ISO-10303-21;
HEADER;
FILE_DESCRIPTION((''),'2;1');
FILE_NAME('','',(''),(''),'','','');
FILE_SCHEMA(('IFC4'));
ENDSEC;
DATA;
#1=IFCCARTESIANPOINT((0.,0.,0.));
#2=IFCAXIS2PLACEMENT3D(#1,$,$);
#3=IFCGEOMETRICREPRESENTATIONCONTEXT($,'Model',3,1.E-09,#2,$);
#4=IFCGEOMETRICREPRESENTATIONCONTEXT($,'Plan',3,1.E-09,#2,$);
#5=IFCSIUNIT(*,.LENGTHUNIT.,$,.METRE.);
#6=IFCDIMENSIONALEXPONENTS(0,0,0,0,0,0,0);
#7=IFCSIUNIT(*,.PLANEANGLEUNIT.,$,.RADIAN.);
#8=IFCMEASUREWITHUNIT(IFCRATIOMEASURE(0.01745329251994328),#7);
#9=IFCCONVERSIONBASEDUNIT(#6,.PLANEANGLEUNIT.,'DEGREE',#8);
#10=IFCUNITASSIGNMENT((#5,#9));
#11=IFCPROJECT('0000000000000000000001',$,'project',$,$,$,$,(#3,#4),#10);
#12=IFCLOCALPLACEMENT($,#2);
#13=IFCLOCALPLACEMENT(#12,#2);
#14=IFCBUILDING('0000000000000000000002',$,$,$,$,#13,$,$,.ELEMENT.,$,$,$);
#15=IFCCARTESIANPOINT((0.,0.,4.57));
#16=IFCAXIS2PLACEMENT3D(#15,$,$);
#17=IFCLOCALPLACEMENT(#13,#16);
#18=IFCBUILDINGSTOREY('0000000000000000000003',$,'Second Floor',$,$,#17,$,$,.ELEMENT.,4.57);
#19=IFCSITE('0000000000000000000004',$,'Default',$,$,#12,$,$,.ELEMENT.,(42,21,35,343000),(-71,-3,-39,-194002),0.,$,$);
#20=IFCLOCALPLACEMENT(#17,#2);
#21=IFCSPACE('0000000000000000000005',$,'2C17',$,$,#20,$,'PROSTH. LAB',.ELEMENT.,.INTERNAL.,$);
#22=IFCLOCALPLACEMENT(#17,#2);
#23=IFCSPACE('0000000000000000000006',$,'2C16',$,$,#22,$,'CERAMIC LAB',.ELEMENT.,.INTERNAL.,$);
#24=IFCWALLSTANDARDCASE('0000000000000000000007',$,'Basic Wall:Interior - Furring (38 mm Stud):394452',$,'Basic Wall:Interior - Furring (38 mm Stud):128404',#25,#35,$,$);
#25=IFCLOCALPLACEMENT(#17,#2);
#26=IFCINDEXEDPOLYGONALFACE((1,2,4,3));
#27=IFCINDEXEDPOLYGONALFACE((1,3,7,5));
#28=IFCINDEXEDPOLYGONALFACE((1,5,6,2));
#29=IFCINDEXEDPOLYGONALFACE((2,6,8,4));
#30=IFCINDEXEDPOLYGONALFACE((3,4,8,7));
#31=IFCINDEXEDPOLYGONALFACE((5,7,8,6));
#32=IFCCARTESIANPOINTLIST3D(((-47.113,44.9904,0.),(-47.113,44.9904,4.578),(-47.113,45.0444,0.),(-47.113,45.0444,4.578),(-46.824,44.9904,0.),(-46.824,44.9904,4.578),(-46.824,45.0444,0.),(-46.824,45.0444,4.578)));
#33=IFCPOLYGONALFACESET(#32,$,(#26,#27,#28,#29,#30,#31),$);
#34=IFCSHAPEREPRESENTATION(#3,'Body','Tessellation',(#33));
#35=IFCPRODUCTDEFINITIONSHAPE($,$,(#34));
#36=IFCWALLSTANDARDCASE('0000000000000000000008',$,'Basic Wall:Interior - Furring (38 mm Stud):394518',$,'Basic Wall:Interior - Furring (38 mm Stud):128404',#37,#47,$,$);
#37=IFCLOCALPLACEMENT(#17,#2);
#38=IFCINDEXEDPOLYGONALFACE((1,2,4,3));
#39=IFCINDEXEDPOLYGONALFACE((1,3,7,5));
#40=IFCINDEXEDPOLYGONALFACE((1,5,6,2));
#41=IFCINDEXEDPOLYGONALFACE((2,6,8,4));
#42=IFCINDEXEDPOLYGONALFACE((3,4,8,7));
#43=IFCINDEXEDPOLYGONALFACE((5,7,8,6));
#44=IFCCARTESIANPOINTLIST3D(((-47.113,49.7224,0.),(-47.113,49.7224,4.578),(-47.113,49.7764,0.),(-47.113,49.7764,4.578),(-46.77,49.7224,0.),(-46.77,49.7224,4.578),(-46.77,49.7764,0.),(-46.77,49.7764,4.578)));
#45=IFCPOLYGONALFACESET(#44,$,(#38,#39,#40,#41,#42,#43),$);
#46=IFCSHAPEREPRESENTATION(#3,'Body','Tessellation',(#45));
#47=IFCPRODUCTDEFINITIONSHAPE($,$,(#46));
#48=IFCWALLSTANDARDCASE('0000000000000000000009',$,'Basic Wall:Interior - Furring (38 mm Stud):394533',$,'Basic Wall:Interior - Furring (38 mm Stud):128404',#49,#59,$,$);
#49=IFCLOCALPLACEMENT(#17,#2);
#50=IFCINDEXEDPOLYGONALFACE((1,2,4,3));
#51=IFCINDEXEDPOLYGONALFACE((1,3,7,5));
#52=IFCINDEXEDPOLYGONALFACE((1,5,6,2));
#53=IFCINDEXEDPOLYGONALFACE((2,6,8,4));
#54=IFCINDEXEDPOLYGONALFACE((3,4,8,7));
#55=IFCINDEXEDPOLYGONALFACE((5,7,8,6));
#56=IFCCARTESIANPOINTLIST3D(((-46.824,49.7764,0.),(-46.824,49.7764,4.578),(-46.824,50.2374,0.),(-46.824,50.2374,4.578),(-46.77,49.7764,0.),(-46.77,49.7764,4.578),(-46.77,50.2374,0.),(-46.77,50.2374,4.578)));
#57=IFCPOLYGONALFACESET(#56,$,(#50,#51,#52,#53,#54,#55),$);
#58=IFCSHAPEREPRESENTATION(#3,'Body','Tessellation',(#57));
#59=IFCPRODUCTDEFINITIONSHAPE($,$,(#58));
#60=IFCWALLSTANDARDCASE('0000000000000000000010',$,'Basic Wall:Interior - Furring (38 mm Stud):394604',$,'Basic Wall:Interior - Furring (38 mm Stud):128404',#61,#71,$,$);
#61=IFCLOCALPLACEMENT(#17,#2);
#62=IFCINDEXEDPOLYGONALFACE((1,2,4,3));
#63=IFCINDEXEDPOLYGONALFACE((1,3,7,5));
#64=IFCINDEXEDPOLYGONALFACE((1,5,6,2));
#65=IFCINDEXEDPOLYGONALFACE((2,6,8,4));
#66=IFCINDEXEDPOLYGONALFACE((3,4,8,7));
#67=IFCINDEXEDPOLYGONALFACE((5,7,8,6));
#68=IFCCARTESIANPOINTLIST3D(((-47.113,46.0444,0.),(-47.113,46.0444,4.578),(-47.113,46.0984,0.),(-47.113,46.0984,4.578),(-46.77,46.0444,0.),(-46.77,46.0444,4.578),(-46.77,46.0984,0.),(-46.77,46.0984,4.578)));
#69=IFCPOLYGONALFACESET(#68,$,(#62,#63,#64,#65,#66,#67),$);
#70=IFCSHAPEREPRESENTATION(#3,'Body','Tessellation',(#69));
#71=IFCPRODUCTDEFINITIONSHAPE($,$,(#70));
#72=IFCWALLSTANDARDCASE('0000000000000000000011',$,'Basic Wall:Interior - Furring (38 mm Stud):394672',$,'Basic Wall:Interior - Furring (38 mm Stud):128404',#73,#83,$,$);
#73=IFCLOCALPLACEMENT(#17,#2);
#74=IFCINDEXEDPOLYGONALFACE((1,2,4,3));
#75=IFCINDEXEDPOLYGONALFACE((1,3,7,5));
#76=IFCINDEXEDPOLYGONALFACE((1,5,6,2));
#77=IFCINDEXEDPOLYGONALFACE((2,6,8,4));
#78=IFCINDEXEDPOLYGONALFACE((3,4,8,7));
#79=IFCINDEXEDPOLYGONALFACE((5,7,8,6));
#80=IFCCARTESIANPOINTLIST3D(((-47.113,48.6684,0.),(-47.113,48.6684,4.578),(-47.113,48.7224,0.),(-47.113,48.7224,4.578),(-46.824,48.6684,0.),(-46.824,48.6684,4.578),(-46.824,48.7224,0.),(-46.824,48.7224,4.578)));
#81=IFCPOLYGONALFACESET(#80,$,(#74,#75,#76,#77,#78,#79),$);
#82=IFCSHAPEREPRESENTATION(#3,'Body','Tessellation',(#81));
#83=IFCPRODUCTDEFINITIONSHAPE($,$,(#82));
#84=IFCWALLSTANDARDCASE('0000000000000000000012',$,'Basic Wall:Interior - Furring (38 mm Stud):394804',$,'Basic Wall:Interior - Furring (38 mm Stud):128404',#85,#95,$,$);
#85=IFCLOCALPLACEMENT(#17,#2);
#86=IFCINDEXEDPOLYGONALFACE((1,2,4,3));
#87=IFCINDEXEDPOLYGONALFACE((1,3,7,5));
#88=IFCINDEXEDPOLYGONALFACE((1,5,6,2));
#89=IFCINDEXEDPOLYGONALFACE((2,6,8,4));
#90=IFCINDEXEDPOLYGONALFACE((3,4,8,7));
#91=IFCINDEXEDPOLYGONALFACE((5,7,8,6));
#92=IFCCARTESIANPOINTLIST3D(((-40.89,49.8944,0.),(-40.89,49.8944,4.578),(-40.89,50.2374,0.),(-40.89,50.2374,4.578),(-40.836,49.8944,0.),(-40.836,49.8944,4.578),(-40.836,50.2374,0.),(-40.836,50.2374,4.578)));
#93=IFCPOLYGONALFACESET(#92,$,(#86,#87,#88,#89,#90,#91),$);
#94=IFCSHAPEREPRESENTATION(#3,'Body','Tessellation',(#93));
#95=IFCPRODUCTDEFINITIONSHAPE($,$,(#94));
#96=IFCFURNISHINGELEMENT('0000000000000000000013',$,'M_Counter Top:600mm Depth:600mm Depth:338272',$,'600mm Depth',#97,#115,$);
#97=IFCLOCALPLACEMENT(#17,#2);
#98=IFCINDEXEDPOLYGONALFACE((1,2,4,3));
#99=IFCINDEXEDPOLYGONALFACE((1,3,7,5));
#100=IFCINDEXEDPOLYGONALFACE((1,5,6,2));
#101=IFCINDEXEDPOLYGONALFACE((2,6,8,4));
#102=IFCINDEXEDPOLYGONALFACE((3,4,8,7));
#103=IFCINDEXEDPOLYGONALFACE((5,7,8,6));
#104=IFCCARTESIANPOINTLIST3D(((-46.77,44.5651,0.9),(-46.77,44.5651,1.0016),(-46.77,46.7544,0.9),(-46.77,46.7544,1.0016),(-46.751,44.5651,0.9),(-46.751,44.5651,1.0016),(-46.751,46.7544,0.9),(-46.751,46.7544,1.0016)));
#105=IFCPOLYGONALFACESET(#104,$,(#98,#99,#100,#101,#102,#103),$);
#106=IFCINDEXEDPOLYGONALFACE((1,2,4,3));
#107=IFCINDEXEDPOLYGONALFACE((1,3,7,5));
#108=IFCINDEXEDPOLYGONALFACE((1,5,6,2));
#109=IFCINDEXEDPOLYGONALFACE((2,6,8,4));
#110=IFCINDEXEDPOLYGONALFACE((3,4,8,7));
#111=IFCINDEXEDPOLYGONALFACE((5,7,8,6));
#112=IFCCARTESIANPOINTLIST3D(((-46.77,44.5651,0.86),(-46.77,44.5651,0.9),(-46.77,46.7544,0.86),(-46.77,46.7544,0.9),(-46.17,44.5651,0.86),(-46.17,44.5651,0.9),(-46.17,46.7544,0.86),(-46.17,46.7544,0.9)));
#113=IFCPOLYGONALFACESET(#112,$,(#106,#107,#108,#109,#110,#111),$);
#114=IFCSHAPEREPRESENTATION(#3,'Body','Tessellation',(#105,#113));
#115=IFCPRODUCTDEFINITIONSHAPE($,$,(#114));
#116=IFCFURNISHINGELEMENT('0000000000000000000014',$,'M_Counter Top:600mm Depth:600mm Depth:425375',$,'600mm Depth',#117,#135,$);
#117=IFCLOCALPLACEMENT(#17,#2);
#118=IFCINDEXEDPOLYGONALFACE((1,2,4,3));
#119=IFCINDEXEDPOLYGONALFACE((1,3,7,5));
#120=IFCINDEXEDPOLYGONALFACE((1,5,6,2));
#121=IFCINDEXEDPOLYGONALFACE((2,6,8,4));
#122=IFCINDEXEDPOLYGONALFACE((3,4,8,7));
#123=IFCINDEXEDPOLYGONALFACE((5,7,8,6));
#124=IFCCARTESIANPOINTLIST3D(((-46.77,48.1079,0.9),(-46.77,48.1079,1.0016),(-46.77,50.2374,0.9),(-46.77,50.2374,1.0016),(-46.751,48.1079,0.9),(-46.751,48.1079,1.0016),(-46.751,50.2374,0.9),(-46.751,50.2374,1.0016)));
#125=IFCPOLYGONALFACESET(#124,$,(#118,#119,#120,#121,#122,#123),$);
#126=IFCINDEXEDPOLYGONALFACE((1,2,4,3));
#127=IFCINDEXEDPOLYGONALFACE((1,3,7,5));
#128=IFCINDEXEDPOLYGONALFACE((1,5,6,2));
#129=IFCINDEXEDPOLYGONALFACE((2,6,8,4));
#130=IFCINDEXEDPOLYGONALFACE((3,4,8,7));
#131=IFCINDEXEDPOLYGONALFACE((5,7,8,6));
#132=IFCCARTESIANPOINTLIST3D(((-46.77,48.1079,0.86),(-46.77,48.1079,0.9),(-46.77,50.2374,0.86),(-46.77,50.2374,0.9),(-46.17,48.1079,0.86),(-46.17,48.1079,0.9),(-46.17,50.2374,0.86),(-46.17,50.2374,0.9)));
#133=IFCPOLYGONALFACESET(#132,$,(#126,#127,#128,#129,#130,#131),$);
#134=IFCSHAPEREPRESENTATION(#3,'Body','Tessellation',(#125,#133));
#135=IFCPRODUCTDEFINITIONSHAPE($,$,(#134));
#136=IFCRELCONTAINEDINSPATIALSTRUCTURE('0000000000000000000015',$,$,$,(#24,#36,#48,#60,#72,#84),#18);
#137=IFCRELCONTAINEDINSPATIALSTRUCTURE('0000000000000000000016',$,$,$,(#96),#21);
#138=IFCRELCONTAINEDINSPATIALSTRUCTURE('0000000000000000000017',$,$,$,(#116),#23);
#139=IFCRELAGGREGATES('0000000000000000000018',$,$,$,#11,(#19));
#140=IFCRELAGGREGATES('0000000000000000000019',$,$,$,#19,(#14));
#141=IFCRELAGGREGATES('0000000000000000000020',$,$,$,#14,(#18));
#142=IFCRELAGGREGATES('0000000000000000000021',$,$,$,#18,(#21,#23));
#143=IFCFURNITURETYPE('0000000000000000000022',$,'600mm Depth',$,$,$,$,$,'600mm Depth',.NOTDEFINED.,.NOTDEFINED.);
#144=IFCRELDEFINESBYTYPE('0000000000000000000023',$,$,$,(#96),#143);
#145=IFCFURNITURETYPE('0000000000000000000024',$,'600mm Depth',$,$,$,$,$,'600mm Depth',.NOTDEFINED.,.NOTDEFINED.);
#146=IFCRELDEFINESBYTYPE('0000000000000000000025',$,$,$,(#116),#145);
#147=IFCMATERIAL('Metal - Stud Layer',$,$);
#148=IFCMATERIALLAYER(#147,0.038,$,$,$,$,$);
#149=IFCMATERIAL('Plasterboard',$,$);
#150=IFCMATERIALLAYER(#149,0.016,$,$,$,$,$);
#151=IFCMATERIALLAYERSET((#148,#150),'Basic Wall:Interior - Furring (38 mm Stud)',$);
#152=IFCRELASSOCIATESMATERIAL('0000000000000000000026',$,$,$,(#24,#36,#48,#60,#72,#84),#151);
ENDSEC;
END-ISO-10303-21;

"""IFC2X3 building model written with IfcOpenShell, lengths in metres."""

from ifc_helpers import new_model, entity, si_unit, converted_unit, frame, frame_2d, origin, origin_2d_with_axis, place, context, project, spatial, rectangle, extrude, source, transform, mapped, material, layer, layer_set, layer_usage, type_object, type_shapes, element, save


model = new_model("IFC2X3")

# Units and contexts
model_context = context("Model", 3, precision=1e-09, world=origin())
plan_context = context("Plan", 3, precision=1e-09, world=origin())
ifc_project = project(units=[si_unit("LENGTHUNIT", "METRE"), converted_unit("PLANEANGLEUNIT", "DEGREE", entity("IfcRatioMeasure", 0.01745329251994328), si_unit("PLANEANGLEUNIT", "RADIAN"), dimensions=[0, 0, 0, 0, 0, 0, 0])], contexts=[model_context, plan_context])

# Site, building, storey
site_placement = place(None, origin())
site = spatial("IfcSite", under=ifc_project, at=site_placement, Name="Default", CompositionType="ELEMENT", RefLatitude=(42, 21, 35, 343000), RefLongitude=(-71, -3, -39, -194002), RefElevation=0.0)
building_placement = place(site_placement, origin())
building = spatial("IfcBuilding", under=site, at=building_placement, CompositionType="ELEMENT")
storey_placement = place(building_placement, frame((0.0, 0.0, 4.57)))
storey = spatial("IfcBuildingStorey", under=building, at=storey_placement, Name="Second Floor", CompositionType="ELEMENT", Elevation=4.57)

# Shared definitions
ifc_material_1 = material(Name="Plasterboard")
ifc_layer_1 = layer(ifc_material_1, 0.016)
ifc_material_2 = material(Name="Metal - Stud Layer")

# Shared definitions
ifc_layer_2 = layer(ifc_material_2, 0.038)
ifc_layer_set_1 = layer_set([ifc_layer_2, ifc_layer_1], Name="Basic Wall:Interior - Furring (38 mm Stud)")
ifc_layer_usage_1 = layer_usage(ifc_layer_set_1, "AXIS2", "NEGATIVE", 0.027)

# Walls
wall_1_placement = place(storey_placement, frame((-46.824, 45.0174, 0.0), z_axis=(0.0, 0.0, 1.0), x_axis=(-1.0, 0.0, 0.0)))
element("IfcWallStandardCase", 1, at=wall_1_placement, inside=storey, material=ifc_layer_usage_1, Name="Basic Wall:Interior - Furring (38 mm Stud):394452", ObjectType="Basic Wall:Interior - Furring (38 mm Stud):128404", context=model_context, shape_type="SweptSolid", body=[
    extrude(rectangle(XDim=0.289, YDim=0.054, at=frame_2d((0.1445, 0.0), x_axis=(-1.0, 0.0))), origin(), (0.0, 0.0, 1.0), 4.578),
])
wall_2_placement = place(storey_placement, frame((-47.113, 49.7494, 0.0)))
element("IfcWallStandardCase", 2, at=wall_2_placement, inside=storey, material=ifc_layer_usage_1, Name="Basic Wall:Interior - Furring (38 mm Stud):394518", ObjectType="Basic Wall:Interior - Furring (38 mm Stud):128404", context=model_context, shape_type="SweptSolid", body=[
    extrude(rectangle(XDim=0.343, YDim=0.054, at=frame_2d((0.1715, 0.0), x_axis=(-1.0, 0.0))), origin(), (0.0, 0.0, 1.0), 4.578),
])
wall_3_placement = place(storey_placement, frame((-46.797, 49.7764, 0.0), z_axis=(0.0, 0.0, 1.0), x_axis=(0.0, 1.0, 0.0)))
element("IfcWallStandardCase", 3, at=wall_3_placement, inside=storey, material=ifc_layer_usage_1, Name="Basic Wall:Interior - Furring (38 mm Stud):394533", ObjectType="Basic Wall:Interior - Furring (38 mm Stud):128404", context=model_context, shape_type="SweptSolid", body=[
    extrude(rectangle(XDim=0.461, YDim=0.054, at=frame_2d((0.2305, 0.0), x_axis=(-1.0, 0.0))), origin(), (0.0, 0.0, 1.0), 4.578),
])
wall_4_placement = place(storey_placement, frame((-47.113, 46.0714, 0.0)))
element("IfcWallStandardCase", 4, at=wall_4_placement, inside=storey, material=ifc_layer_usage_1, Name="Basic Wall:Interior - Furring (38 mm Stud):394604", ObjectType="Basic Wall:Interior - Furring (38 mm Stud):128404", context=model_context, shape_type="SweptSolid", body=[
    extrude(rectangle(XDim=0.343, YDim=0.054, at=frame_2d((0.1715, 0.0), x_axis=(-1.0, 0.0))), origin(), (0.0, 0.0, 1.0), 4.578),
])
wall_5_placement = place(storey_placement, frame((-46.824, 48.6954, 0.0), z_axis=(0.0, 0.0, 1.0), x_axis=(-1.0, 0.0, 0.0)))
element("IfcWallStandardCase", 5, at=wall_5_placement, inside=storey, material=ifc_layer_usage_1, Name="Basic Wall:Interior - Furring (38 mm Stud):394672", ObjectType="Basic Wall:Interior - Furring (38 mm Stud):128404", context=model_context, shape_type="SweptSolid", body=[
    extrude(rectangle(XDim=0.289, YDim=0.054, at=frame_2d((0.1445, 0.0), x_axis=(-1.0, 0.0))), origin(), (0.0, 0.0, 1.0), 4.578),
])
wall_6_placement = place(storey_placement, frame((-40.863, 50.2374, 0.0), z_axis=(0.0, 0.0, 1.0), x_axis=(0.0, -1.0, 0.0)))
element("IfcWallStandardCase", 6, at=wall_6_placement, inside=storey, material=ifc_layer_usage_1, Name="Basic Wall:Interior - Furring (38 mm Stud):394804", ObjectType="Basic Wall:Interior - Furring (38 mm Stud):128404", context=model_context, shape_type="SweptSolid", body=[
    extrude(rectangle(XDim=0.343, YDim=0.054, at=frame_2d((0.1715, 0.0), x_axis=(-1.0, 0.0))), origin(), (0.0, 0.0, 1.0), 4.578),
])

# Shared definitions
space_1_placement = place(storey_placement, origin())
space_1 = spatial("IfcSpace", under=storey, at=space_1_placement, Name="2C17", LongName="PROSTH. LAB", CompositionType="ELEMENT", InteriorOrExteriorSpace="INTERNAL")

# Furnishing element
furniture_type_1 = type_object("IfcFurnitureType", Name="600mm Depth", ElementType="600mm Depth", AssemblyPlace="NOTDEFINED")
shared_shape_1 = source(origin(), model_context, "Body", "SweptSolid", [
    extrude(rectangle(XDim=0.0191, YDim=2.1893, at=origin_2d_with_axis()), frame((-0.1058, -0.0095, 0.9), z_axis=(0.0, 0.0, 1.0), x_axis=(0.0, -1.0, 0.0)), (0.0, 0.0, 1.0), 0.1016),
    extrude(rectangle(XDim=2.1893, YDim=0.6, at=origin_2d_with_axis()), frame((-0.1058, -0.3, 0.86), z_axis=(0.0, 0.0, 1.0), x_axis=(-1.0, 0.0, 0.0)), (0.0, 0.0, 1.0), 0.04),
])
type_shapes(furniture_type_1, [shared_shape_1])
furnishing_1_placement = place(space_1_placement, frame((-46.77, 45.7656, 0.0), z_axis=(0.0, 0.0, 1.0), x_axis=(0.0, 1.0, 0.0)))
element("IfcFurnishingElement", 7, at=furnishing_1_placement, inside=space_1, type_object=furniture_type_1, Name="M_Counter Top:600mm Depth:600mm Depth:338272", ObjectType="600mm Depth", context=model_context, shape_type="MappedRepresentation", body=[
    mapped(shared_shape_1, transform((0.0, 0.0, 0.0), scale=1.0)),
])

# Shared definitions
space_2_placement = place(storey_placement, origin())
space_2 = spatial("IfcSpace", under=storey, at=space_2_placement, Name="2C16", LongName="CERAMIC LAB", CompositionType="ELEMENT", InteriorOrExteriorSpace="INTERNAL")

# Furnishing element
furniture_type_2 = type_object("IfcFurnitureType", Name="600mm Depth", ElementType="600mm Depth", AssemblyPlace="NOTDEFINED")
shared_shape_2 = source(origin(), model_context, "Body", "SweptSolid", [
    extrude(rectangle(XDim=0.0191, YDim=2.1295, at=origin_2d_with_axis()), frame((-0.1357, -0.0095, 0.9), z_axis=(0.0, 0.0, 1.0), x_axis=(0.0, -1.0, 0.0)), (0.0, 0.0, 1.0), 0.1016),
    extrude(rectangle(XDim=2.1295, YDim=0.6, at=origin_2d_with_axis()), frame((-0.1357, -0.3, 0.86), z_axis=(0.0, 0.0, 1.0), x_axis=(-1.0, 0.0, 0.0)), (0.0, 0.0, 1.0), 0.04),
])
type_shapes(furniture_type_2, [shared_shape_2])
furnishing_2_placement = place(space_2_placement, frame((-46.77, 49.3084, 0.0), z_axis=(0.0, 0.0, 1.0), x_axis=(0.0, 1.0, 0.0)))
element("IfcFurnishingElement", 8, at=furnishing_2_placement, inside=space_2, type_object=furniture_type_2, Name="M_Counter Top:600mm Depth:600mm Depth:425375", ObjectType="600mm Depth", context=model_context, shape_type="MappedRepresentation", body=[
    mapped(shared_shape_2, transform((0.0, 0.0, 0.0), scale=1.0)),
])

save(model, "model.ifc")
